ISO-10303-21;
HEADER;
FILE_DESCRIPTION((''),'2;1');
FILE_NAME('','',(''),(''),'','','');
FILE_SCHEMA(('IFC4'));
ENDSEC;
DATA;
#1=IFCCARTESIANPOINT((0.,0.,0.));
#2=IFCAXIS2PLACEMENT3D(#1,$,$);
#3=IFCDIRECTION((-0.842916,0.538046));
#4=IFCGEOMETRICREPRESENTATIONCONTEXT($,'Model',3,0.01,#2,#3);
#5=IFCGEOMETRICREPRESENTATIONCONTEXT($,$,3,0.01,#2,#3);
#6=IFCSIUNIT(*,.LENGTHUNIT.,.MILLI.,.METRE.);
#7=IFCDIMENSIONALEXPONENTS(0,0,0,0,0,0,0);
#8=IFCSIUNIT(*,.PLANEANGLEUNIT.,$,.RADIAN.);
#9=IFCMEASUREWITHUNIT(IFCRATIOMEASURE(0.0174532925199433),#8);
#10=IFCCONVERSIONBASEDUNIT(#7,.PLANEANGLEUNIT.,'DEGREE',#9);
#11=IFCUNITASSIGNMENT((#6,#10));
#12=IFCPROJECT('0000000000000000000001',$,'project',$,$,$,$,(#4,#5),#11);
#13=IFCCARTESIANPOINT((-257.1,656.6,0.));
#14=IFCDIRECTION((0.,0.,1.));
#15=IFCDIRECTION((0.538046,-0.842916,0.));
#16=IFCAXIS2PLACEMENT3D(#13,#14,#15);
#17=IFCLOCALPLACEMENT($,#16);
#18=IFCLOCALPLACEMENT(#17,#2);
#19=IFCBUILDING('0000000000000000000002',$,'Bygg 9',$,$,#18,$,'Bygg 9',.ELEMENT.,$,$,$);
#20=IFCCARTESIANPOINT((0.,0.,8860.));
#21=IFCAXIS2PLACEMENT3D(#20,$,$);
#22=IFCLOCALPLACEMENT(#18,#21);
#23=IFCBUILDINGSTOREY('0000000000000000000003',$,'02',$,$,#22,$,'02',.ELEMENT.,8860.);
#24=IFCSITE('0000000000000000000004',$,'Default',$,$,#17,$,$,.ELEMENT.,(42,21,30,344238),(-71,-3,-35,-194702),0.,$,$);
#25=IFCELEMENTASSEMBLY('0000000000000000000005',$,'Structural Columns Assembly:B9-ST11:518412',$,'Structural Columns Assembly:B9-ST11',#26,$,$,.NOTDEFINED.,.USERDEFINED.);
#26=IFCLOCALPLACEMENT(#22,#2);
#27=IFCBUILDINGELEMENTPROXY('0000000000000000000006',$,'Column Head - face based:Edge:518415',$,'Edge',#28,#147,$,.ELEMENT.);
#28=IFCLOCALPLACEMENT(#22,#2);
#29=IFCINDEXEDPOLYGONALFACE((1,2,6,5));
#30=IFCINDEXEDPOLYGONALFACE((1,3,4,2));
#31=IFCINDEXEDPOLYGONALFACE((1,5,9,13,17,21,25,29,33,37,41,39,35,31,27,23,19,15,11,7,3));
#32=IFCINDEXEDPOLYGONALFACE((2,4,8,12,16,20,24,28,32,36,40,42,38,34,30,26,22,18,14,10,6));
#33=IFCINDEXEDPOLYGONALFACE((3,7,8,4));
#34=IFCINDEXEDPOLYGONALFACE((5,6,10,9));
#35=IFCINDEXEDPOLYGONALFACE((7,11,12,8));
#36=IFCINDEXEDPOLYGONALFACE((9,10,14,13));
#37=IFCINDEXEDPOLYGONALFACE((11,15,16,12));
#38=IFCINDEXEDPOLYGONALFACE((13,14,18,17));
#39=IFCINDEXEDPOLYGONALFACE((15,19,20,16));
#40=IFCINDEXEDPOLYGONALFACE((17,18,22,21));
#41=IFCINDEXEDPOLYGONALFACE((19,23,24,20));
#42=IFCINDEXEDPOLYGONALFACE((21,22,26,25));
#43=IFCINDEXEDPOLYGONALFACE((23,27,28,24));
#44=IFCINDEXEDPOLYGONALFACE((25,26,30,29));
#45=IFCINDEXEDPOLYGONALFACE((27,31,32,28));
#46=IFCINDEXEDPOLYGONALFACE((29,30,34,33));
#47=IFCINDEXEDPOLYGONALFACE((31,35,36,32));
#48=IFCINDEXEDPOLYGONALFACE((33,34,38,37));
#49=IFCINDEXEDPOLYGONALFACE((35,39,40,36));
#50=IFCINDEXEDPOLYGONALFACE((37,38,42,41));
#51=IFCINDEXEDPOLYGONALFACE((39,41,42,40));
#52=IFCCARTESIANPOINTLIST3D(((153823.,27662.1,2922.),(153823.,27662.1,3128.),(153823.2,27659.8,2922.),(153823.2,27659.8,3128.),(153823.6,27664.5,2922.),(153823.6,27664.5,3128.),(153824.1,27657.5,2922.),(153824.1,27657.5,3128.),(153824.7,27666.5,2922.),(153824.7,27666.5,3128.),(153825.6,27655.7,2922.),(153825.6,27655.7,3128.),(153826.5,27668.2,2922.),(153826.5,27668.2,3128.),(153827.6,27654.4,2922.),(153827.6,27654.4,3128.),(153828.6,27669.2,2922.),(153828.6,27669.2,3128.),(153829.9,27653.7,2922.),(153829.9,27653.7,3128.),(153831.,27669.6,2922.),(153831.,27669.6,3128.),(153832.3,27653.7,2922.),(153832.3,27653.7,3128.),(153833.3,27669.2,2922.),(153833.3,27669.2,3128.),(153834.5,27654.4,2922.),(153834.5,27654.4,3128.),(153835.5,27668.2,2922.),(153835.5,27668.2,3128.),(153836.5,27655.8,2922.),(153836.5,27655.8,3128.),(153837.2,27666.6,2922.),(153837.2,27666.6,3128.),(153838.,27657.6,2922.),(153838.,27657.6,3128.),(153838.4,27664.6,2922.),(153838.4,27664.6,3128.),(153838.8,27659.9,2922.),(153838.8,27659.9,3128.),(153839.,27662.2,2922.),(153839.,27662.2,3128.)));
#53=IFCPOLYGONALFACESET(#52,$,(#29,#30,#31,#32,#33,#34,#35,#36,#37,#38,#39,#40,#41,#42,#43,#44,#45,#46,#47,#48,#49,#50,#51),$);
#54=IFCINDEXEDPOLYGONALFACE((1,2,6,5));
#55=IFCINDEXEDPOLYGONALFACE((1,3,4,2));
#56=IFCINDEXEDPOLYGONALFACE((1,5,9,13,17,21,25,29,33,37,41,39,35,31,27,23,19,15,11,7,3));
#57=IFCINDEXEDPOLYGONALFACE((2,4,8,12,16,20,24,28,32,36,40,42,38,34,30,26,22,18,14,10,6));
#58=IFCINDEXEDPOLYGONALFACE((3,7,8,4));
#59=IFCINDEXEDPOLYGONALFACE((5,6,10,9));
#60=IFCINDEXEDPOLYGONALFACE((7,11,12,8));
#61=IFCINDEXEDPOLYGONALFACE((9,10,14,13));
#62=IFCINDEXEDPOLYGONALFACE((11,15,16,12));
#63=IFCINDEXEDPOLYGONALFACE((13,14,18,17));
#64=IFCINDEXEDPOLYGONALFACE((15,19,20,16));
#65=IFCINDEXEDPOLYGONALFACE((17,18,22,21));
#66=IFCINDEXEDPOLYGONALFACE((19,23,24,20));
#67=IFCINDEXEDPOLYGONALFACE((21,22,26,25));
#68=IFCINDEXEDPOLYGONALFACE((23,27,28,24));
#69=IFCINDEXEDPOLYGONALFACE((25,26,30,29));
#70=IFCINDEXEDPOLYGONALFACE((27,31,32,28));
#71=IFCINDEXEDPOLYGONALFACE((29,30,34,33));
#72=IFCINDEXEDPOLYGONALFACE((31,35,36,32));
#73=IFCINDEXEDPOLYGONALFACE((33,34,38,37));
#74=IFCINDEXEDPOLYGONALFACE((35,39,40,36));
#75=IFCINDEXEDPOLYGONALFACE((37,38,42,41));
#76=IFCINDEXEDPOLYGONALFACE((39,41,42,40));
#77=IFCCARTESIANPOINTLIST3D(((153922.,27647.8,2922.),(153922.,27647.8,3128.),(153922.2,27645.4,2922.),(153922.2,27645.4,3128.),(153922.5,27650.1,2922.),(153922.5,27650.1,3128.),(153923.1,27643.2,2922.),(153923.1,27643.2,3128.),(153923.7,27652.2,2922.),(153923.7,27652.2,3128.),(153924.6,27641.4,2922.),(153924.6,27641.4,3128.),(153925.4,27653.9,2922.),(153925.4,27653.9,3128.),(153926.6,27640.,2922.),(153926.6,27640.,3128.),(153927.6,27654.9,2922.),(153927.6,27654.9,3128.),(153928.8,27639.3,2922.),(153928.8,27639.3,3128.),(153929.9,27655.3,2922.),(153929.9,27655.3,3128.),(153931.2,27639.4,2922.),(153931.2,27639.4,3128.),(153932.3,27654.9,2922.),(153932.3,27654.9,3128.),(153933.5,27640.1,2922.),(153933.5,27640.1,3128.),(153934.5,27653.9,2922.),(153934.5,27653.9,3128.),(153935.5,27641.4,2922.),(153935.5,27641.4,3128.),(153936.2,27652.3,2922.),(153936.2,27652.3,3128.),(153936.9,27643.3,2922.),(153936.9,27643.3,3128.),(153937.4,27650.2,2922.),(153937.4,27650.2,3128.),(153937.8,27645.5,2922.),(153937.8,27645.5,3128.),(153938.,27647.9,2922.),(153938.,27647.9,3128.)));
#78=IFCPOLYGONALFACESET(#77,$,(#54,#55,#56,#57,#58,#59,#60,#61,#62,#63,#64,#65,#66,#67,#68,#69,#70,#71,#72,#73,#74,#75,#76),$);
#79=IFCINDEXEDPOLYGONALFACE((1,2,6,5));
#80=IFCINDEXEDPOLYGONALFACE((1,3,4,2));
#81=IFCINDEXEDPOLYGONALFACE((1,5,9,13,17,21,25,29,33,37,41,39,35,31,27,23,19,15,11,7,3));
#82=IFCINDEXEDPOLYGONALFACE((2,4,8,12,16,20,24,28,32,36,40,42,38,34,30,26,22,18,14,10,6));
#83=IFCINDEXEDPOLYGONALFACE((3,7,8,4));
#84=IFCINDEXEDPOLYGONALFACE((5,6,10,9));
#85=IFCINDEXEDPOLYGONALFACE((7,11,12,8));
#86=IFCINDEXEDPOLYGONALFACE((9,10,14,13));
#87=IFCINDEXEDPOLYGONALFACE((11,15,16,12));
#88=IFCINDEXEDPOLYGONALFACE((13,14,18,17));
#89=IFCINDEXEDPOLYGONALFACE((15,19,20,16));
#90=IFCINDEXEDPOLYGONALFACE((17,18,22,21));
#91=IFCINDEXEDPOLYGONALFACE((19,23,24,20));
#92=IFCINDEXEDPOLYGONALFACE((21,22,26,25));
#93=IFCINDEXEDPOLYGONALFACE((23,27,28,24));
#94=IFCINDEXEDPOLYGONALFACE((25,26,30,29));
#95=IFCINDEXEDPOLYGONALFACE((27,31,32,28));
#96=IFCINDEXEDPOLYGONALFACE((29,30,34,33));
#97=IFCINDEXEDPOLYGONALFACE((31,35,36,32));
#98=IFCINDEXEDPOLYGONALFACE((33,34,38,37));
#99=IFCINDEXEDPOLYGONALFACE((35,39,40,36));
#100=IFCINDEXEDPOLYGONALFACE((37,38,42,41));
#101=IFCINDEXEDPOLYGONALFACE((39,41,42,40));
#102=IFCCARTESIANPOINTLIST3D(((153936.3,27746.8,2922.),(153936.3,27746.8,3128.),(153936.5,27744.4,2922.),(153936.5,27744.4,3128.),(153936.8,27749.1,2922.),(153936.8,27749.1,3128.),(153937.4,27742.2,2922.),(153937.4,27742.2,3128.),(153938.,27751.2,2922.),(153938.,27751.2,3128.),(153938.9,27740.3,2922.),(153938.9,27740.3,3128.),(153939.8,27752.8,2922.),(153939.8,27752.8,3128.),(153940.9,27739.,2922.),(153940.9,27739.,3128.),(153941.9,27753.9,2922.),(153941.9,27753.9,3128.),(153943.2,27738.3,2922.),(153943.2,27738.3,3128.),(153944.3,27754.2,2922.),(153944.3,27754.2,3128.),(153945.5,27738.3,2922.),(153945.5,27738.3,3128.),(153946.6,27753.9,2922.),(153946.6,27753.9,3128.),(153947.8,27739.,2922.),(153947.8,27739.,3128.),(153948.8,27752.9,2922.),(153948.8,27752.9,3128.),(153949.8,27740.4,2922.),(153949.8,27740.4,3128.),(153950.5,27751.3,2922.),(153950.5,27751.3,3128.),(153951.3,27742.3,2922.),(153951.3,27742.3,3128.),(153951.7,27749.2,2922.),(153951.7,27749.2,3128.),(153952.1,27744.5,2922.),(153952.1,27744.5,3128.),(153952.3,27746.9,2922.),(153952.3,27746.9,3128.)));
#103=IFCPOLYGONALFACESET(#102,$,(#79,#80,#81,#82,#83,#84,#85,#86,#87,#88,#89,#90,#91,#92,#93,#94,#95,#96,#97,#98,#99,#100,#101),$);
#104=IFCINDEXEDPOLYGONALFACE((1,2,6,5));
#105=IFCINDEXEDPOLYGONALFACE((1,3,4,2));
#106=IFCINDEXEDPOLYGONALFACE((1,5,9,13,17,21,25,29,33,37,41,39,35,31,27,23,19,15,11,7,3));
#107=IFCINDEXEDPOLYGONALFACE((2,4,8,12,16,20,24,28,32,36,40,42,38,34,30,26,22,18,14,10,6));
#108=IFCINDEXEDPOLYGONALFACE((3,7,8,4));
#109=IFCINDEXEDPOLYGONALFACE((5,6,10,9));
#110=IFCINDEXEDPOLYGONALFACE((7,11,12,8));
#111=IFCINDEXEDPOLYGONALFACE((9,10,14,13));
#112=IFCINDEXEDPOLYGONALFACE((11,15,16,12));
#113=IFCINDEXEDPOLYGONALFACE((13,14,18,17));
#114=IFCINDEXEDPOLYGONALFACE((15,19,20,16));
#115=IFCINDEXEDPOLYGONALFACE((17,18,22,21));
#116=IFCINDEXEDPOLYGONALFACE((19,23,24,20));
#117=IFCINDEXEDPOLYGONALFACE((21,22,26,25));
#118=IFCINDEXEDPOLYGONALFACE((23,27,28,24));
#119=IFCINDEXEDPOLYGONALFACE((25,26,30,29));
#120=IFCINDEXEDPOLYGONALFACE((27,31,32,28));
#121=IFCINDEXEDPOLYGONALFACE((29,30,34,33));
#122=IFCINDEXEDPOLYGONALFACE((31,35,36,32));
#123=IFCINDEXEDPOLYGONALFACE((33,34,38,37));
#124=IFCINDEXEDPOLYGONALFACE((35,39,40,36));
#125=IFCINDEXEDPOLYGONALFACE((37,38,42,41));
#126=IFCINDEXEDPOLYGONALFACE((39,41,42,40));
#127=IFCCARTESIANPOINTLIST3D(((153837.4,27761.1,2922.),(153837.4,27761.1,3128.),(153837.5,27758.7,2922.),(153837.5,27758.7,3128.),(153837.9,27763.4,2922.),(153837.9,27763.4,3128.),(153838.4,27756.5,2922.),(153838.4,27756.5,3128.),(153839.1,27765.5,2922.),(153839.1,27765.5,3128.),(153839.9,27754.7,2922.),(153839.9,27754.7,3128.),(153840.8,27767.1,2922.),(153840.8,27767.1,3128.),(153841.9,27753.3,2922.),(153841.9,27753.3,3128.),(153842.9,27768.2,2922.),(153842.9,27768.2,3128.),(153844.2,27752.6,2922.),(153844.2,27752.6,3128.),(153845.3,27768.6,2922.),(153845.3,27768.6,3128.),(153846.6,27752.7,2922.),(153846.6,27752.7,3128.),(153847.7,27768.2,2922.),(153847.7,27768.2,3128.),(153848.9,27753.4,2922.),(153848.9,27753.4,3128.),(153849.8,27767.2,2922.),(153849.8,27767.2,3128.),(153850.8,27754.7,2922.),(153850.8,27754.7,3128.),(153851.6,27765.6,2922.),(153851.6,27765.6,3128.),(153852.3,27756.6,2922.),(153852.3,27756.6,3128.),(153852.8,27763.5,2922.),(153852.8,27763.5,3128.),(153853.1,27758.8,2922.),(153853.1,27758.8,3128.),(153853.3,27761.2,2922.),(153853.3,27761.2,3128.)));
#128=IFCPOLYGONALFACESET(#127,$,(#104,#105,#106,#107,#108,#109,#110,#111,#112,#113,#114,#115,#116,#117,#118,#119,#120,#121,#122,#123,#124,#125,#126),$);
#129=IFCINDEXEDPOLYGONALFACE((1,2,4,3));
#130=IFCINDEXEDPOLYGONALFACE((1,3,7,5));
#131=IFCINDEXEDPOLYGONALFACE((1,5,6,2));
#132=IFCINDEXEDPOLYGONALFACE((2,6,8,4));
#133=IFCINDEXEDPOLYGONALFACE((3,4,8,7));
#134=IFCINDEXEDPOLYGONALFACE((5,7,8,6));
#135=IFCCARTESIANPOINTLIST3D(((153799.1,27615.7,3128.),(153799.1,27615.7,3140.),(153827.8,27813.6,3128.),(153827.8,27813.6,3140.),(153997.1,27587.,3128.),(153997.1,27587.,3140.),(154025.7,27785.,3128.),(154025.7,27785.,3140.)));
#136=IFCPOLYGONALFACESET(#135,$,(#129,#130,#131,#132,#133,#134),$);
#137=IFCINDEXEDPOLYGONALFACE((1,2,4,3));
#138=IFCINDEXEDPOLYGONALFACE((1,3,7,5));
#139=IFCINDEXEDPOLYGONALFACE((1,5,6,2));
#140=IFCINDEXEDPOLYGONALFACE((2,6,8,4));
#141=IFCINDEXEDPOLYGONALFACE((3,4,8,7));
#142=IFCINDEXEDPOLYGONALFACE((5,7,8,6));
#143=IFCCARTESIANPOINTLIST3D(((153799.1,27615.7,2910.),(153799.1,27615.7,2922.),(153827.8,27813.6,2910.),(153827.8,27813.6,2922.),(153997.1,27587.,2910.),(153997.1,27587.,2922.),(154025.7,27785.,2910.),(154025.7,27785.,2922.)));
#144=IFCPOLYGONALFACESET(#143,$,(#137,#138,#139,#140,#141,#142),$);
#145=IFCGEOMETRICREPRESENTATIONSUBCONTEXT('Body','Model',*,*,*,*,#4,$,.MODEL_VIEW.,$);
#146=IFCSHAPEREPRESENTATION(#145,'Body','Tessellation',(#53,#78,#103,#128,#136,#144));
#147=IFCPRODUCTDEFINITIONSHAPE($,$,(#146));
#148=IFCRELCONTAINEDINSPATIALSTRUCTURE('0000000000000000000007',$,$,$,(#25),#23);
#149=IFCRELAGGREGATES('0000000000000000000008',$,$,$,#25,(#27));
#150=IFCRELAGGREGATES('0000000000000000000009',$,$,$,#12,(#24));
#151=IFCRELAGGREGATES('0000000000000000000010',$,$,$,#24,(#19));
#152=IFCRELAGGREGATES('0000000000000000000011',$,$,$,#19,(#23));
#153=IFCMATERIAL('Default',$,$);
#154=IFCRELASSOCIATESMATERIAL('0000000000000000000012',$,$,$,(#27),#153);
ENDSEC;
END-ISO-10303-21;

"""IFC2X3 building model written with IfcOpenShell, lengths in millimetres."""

from ifc_helpers import new_model, entity, si_unit, converted_unit, direction, frame, frame_2d, origin, origin_2d_with_axis, place, context, subcontext, project, spatial, rectangle, circle, extrude, source, transform, mapped, material, element, aggregate, save


model = new_model("IFC2X3")

# Units and contexts
model_context = context("Model", 3, precision=0.01, world=origin(), true_north=direction((-0.842916, 0.538046)))
context_of_model = context(None, 3, precision=0.01, world=origin(), true_north=direction((-0.842916, 0.538046)))
body_context = subcontext(model_context, "Body", "Model", "MODEL_VIEW")
ifc_project = project(units=[si_unit("LENGTHUNIT", "METRE", prefix="MILLI"), converted_unit("PLANEANGLEUNIT", "DEGREE", entity("IfcRatioMeasure", 0.0174532925199433), si_unit("PLANEANGLEUNIT", "RADIAN"), dimensions=[0, 0, 0, 0, 0, 0, 0])], contexts=[model_context, context_of_model])

# Site, building, storey
site_placement = place(None, frame((-257.1, 656.6, 0.0), z_axis=(0.0, 0.0, 1.0), x_axis=(0.538046, -0.842916, 0.0)))
site = spatial("IfcSite", under=ifc_project, at=site_placement, Name="Default", CompositionType="ELEMENT", RefLatitude=(42, 21, 30, 344238), RefLongitude=(-71, -3, -35, -194702), RefElevation=0.0)
building_placement = place(site_placement, origin())
building = spatial("IfcBuilding", under=site, at=building_placement, Name="Bygg 9", LongName="Bygg 9", CompositionType="ELEMENT")
storey_placement = place(building_placement, frame((0.0, 0.0, 8860.0)))
storey = spatial("IfcBuildingStorey", under=building, at=storey_placement, Name="02", LongName="02", CompositionType="ELEMENT", Elevation=8860.0)

# Element assembly
assembly_1_placement = place(storey_placement, origin())
assembly_1 = element("IfcElementAssembly", 1, at=assembly_1_placement, inside=storey, Name="Structural Columns Assembly:B9-ST11:518412", ObjectType="Structural Columns Assembly:B9-ST11", AssemblyPlace="NOTDEFINED", PredefinedType="USERDEFINED")

# Building element proxy
ifc_material_1 = material(Name="Default")
shared_shape_1 = source(origin(), body_context, "Body", "SweptSolid", [
    extrude(circle(Radius=8.0, at=frame_2d((0.0, 0.0), x_axis=(1.0, 0.0))), frame((50.0, -75.0, 12.0)), (0.0, 0.0, 1.0), 206.0),
    extrude(circle(Radius=8.0, at=frame_2d((0.0, 0.0), x_axis=(1.0, 0.0))), frame((50.0, 25.0, 12.0)), (0.0, 0.0, 1.0), 206.0),
    extrude(circle(Radius=8.0, at=frame_2d((0.0, 0.0), x_axis=(1.0, 0.0))), frame((-50.0, 25.0, 12.0)), (0.0, 0.0, 1.0), 206.0),
    extrude(circle(Radius=8.0, at=frame_2d((0.0, 0.0), x_axis=(1.0, 0.0))), frame((-50.0, -75.0, 12.0)), (0.0, 0.0, 1.0), 206.0),
    extrude(rectangle(XDim=200.0, YDim=200.0, at=origin_2d_with_axis()), frame((0.0, 0.0, 218.0), z_axis=(0.0, 0.0, 1.0), x_axis=(-1.0, 0.0, 0.0)), (0.0, 0.0, 1.0), 12.0),
    extrude(rectangle(XDim=200.0, YDim=200.0, at=origin_2d_with_axis()), frame((0.0, 0.0, 0.0), z_axis=(0.0, 0.0, 1.0), x_axis=(0.0, 1.0, 0.0)), (0.0, 0.0, 1.0), 12.0),
])
proxy_1_placement = place(assembly_1_placement, frame((153912.4, 27700.3, 2910.0), z_axis=(0.0, 0.0, 1.0), x_axis=(-0.143216, -0.989691, 0.0)))
proxy_1 = element("IfcBuildingElementProxy", 2, at=proxy_1_placement, material=ifc_material_1, Name="Column Head - face based:Edge:518415", ObjectType="Edge", CompositionType="ELEMENT", context=body_context, shape_type="MappedRepresentation", body=[
    mapped(shared_shape_1, transform((0.0, 0.0, 0.0), scale=1.0)),
])
aggregate(assembly_1, [proxy_1])

save(model, "model.ifc")
